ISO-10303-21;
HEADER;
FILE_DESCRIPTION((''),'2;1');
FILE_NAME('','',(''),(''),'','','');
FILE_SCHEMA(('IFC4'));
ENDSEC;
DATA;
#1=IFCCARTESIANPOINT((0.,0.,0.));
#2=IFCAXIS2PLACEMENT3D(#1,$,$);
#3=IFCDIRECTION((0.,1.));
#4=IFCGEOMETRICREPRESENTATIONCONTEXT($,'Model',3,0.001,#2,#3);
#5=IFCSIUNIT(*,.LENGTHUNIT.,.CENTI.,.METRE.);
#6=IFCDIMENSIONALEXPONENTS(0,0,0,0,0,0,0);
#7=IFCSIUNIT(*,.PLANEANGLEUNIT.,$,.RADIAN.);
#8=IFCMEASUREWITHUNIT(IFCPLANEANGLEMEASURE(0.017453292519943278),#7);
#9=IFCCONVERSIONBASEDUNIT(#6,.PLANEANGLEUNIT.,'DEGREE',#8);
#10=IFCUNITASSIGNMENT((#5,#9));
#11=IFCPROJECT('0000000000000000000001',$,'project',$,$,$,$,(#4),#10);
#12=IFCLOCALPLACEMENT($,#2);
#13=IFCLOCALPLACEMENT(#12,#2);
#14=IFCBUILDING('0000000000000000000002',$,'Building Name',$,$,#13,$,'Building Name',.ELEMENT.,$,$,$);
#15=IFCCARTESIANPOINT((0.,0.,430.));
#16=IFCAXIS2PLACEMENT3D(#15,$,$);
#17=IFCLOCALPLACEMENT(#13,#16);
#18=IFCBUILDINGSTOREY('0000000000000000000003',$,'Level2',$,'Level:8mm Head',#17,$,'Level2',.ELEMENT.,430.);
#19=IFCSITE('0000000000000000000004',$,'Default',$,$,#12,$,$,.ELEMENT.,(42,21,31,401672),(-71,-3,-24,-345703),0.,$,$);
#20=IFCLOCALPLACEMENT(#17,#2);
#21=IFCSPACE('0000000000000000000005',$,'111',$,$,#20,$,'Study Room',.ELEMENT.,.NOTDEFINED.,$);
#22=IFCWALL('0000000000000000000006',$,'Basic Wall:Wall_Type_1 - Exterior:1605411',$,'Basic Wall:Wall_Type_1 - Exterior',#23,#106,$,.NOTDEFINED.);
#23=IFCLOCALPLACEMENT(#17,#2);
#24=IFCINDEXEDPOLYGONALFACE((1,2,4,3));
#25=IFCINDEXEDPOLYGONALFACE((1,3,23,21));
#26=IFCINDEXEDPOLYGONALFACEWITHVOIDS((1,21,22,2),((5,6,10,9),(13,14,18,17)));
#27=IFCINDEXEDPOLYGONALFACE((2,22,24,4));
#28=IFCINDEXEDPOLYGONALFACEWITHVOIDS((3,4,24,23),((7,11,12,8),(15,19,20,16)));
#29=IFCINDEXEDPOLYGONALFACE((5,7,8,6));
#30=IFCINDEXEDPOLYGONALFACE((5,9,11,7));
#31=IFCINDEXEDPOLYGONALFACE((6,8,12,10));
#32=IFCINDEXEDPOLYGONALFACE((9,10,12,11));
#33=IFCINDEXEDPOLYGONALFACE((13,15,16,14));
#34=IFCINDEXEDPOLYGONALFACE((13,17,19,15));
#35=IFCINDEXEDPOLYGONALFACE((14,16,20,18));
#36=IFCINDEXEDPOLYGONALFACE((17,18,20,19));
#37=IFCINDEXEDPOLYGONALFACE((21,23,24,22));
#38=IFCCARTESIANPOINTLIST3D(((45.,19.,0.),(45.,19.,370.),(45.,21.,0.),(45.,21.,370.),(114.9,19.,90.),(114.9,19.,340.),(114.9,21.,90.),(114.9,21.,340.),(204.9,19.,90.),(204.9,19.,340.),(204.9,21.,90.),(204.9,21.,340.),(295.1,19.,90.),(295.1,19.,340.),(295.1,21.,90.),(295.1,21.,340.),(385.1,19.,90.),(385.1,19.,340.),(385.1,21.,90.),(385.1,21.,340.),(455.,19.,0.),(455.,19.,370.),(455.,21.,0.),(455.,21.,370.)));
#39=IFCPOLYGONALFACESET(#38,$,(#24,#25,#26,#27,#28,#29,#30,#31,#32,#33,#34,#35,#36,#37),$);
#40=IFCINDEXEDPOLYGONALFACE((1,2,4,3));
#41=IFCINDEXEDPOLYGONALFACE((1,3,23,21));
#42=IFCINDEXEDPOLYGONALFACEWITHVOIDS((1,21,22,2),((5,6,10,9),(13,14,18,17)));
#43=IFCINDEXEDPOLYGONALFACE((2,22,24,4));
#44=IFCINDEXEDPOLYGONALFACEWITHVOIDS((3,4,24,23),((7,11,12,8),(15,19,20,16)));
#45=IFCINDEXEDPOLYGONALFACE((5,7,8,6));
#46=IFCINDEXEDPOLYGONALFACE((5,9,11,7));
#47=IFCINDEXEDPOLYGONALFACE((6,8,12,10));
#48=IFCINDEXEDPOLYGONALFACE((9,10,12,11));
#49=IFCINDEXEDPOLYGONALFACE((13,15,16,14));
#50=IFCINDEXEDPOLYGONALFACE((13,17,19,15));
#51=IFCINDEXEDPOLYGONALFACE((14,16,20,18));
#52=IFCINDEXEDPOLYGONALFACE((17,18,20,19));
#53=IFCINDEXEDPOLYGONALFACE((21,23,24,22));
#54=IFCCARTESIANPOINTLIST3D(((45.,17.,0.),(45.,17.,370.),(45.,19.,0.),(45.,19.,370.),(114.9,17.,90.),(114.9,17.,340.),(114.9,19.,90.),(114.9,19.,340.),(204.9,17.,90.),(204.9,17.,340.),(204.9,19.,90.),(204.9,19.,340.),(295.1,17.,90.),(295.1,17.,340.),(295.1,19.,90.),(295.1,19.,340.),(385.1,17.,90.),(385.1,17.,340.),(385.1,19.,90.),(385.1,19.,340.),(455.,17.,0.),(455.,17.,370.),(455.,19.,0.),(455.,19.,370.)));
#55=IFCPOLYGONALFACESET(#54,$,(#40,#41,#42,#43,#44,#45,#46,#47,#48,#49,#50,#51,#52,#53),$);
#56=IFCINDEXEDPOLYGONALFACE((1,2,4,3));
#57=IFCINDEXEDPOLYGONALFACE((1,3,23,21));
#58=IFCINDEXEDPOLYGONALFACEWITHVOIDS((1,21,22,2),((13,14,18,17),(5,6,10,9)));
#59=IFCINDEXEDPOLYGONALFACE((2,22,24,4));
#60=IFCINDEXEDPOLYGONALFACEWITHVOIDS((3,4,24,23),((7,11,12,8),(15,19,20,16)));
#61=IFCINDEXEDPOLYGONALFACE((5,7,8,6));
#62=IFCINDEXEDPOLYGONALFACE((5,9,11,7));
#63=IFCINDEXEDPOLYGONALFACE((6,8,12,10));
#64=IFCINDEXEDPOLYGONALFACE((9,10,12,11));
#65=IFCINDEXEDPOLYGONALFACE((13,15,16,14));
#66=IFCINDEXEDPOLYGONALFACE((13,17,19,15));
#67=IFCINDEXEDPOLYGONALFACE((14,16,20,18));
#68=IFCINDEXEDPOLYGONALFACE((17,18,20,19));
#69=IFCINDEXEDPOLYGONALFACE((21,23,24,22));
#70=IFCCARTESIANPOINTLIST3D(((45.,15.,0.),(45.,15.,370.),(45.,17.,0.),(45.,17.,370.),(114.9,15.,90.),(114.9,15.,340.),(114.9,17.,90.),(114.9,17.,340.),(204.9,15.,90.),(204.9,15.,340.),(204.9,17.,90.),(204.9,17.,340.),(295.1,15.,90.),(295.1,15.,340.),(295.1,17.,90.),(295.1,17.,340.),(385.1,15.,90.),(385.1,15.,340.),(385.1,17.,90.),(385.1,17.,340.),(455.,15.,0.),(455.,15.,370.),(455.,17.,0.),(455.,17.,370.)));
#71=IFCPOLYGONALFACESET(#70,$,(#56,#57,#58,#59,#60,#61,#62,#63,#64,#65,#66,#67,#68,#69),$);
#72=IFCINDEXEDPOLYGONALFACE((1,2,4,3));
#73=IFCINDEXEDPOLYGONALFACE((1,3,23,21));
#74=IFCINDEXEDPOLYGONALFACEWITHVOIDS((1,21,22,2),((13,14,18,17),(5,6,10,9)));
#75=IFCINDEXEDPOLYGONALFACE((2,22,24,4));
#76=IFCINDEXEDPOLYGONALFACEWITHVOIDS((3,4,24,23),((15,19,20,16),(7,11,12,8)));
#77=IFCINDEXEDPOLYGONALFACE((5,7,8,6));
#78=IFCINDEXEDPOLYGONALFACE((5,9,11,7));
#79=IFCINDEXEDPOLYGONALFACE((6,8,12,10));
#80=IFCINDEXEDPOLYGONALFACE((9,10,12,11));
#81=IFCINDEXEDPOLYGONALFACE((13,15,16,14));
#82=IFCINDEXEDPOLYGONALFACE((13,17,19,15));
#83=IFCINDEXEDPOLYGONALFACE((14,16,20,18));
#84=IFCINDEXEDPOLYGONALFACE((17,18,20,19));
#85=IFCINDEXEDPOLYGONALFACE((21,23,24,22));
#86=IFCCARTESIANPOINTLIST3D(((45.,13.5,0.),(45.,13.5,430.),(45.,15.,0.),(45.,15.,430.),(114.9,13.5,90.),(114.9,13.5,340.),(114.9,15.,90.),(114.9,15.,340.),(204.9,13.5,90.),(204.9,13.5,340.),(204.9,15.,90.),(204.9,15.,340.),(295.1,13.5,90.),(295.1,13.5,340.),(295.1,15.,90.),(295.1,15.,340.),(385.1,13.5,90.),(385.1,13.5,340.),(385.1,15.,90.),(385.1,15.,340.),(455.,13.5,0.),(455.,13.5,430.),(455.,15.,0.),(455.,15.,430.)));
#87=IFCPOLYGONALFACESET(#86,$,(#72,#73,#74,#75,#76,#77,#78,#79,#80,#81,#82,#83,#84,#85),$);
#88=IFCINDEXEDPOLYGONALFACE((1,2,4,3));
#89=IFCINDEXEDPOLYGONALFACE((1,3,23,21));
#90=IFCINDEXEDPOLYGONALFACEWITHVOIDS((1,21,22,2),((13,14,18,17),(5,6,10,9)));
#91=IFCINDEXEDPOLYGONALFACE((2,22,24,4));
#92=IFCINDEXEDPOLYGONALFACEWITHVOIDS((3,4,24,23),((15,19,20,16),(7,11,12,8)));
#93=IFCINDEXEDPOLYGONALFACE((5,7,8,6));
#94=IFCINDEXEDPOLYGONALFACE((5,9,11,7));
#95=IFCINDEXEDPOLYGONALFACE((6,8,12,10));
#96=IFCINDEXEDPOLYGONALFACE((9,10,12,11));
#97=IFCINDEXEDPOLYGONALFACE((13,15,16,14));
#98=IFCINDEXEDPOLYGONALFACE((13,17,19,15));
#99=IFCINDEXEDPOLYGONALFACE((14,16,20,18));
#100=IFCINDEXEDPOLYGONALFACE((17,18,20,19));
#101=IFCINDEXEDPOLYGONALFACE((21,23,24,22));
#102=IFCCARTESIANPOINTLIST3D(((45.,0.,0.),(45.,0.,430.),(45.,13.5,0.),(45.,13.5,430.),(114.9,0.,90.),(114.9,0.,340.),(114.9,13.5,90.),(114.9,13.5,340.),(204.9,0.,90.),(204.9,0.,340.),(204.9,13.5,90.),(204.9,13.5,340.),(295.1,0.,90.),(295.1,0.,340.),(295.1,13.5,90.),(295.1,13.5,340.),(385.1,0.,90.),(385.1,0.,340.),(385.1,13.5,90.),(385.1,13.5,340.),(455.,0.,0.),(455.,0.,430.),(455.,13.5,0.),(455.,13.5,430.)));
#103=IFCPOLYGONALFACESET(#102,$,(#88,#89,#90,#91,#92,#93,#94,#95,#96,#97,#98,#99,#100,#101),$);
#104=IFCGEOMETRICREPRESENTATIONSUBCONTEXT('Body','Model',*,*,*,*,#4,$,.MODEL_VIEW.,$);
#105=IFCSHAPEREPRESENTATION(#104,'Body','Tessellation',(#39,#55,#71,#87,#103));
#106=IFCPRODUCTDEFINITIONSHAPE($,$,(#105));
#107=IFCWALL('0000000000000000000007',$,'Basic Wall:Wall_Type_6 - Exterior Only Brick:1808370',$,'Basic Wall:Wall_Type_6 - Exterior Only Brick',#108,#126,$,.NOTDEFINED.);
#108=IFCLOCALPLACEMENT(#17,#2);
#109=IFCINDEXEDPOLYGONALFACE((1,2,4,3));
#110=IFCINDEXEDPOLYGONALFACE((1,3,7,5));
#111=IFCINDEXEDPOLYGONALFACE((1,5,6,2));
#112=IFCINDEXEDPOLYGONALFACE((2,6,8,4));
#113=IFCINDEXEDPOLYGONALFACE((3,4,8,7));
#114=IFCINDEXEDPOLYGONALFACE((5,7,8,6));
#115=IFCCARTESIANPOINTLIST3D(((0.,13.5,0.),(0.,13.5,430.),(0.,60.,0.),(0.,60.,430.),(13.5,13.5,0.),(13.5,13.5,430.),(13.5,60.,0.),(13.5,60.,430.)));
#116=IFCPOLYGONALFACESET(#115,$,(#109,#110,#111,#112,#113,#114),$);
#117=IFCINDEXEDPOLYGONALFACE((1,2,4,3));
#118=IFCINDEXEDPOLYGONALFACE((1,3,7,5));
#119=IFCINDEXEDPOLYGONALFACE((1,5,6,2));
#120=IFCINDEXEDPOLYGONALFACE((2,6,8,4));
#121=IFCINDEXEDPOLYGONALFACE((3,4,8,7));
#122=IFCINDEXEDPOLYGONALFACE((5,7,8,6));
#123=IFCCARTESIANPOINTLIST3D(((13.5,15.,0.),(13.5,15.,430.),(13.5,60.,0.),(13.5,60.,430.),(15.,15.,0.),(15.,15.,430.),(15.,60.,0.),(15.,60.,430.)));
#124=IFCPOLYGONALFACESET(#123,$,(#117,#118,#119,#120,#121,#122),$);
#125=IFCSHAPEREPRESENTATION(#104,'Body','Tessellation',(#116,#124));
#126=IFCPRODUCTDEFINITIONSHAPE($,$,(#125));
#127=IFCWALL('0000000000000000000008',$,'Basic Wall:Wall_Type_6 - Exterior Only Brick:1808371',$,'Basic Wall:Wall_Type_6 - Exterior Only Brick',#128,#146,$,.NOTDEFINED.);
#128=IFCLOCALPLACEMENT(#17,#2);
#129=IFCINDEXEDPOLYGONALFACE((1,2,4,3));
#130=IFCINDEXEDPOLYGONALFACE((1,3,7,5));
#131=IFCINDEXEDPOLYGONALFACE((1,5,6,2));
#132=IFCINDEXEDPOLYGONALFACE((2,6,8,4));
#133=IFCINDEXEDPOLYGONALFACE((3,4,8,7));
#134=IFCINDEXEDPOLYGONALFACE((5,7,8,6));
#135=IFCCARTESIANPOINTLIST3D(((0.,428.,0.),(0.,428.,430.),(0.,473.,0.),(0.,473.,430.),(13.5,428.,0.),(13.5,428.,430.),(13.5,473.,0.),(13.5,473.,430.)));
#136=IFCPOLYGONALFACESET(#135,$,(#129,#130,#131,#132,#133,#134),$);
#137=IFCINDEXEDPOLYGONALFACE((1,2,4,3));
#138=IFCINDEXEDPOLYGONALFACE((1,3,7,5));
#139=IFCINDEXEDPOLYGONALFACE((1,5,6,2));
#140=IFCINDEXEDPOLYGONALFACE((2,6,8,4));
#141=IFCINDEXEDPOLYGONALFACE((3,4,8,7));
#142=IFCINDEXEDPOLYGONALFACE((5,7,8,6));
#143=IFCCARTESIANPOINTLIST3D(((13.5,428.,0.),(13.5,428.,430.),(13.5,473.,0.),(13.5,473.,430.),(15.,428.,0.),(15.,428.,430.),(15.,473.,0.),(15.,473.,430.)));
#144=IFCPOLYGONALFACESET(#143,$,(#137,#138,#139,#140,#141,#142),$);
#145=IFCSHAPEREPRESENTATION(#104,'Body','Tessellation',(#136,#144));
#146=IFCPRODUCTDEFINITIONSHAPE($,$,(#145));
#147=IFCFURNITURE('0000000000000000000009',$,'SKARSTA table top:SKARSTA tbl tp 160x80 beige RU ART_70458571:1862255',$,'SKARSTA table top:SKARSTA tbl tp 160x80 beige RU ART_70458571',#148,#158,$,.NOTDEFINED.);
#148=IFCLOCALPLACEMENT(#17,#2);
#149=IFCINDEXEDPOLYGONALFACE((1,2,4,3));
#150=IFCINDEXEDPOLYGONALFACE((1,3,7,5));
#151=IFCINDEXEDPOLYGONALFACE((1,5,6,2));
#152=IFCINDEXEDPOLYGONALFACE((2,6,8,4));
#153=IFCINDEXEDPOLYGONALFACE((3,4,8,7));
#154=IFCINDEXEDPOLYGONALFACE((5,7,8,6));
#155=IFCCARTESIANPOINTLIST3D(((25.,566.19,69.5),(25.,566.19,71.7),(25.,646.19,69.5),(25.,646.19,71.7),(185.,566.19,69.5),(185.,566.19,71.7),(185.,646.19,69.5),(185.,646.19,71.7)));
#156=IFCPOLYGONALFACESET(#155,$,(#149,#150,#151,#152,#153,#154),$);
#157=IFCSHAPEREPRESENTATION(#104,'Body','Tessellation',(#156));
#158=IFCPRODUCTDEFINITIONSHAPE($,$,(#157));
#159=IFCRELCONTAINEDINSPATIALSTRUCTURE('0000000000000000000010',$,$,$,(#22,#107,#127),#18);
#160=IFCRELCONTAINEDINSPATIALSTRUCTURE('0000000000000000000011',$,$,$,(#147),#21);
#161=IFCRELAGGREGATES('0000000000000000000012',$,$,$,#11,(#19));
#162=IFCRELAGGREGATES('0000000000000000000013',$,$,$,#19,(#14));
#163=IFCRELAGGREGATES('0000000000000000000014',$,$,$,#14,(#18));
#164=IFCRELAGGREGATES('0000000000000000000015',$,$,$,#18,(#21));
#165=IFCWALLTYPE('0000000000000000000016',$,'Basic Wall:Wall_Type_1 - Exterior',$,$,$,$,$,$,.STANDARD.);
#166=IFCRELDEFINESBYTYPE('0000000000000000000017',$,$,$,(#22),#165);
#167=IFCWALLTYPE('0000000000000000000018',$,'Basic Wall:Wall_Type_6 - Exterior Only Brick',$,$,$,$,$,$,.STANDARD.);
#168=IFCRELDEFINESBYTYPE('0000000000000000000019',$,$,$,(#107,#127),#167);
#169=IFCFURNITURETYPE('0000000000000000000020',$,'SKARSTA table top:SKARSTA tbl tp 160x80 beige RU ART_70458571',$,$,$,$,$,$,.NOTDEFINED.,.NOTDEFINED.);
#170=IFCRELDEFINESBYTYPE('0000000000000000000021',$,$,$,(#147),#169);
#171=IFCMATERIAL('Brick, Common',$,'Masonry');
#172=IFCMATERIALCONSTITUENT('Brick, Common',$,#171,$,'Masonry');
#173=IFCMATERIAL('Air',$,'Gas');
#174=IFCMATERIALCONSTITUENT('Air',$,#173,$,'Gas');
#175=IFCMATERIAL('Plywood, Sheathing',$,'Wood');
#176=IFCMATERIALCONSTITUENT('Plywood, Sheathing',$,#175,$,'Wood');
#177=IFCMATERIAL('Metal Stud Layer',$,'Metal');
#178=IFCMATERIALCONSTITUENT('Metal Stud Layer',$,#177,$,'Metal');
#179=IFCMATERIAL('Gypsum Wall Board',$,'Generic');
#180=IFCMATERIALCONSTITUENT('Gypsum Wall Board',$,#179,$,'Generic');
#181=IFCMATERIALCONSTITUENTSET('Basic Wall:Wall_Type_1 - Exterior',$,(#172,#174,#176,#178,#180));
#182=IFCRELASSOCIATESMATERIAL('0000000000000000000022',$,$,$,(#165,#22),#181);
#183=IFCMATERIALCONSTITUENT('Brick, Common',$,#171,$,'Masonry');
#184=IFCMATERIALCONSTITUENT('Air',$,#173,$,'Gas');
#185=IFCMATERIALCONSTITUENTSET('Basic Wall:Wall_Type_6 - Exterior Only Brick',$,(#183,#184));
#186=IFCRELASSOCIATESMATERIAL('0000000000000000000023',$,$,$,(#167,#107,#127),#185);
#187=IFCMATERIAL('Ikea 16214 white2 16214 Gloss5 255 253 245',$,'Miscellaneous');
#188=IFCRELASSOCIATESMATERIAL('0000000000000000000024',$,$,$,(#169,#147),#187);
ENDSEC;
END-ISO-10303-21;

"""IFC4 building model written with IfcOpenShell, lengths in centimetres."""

from ifc_helpers import new_model, entity, si_unit, converted_unit, direction, frame, origin, place, context, subcontext, project, spatial, indexed_curve, outline, extrude, source, transform, mapped, material, constituent, constituent_set, type_object, type_shapes, element, save


model = new_model("IFC4")

# Units and contexts
model_context = context("Model", 3, precision=0.001, world=origin(), true_north=direction((0.0, 1.0)))
body_context = subcontext(model_context, "Body", "Model", "MODEL_VIEW")
ifc_project = project(units=[si_unit("LENGTHUNIT", "METRE", prefix="CENTI"), converted_unit("PLANEANGLEUNIT", "DEGREE", entity("IfcPlaneAngleMeasure", 0.017453292519943278), si_unit("PLANEANGLEUNIT", "RADIAN"), dimensions=[0, 0, 0, 0, 0, 0, 0])], contexts=[model_context])

# Site, building, storey
site_placement = place(None, origin())
site = spatial("IfcSite", under=ifc_project, at=site_placement, Name="Default", CompositionType="ELEMENT", RefLatitude=(42, 21, 31, 401672), RefLongitude=(-71, -3, -24, -345703), RefElevation=0.0)
building_placement = place(site_placement, origin())
building = spatial("IfcBuilding", under=site, at=building_placement, Name="Building Name", LongName="Building Name", CompositionType="ELEMENT")
storey_placement = place(building_placement, frame((0.0, 0.0, 430.0)))
storey = spatial("IfcBuildingStorey", under=building, at=storey_placement, Name="Level2", ObjectType="Level:8mm Head", LongName="Level2", CompositionType="ELEMENT", Elevation=430.0)

# Shared definitions
ifc_material_1 = material(Name="Brick, Common", Category="Masonry")
ifc_constituent_1 = constituent(ifc_material_1, Name="Brick, Common", Category="Masonry")
ifc_material_2 = material(Name="Air", Category="Gas")
ifc_constituent_2 = constituent(ifc_material_2, Name="Air", Category="Gas")
ifc_material_3 = material(Name="Plywood, Sheathing", Category="Wood")
ifc_constituent_3 = constituent(ifc_material_3, Name="Plywood, Sheathing", Category="Wood")
ifc_material_4 = material(Name="Metal Stud Layer", Category="Metal")
ifc_constituent_4 = constituent(ifc_material_4, Name="Metal Stud Layer", Category="Metal")
ifc_material_5 = material(Name="Gypsum Wall Board", Category="Generic")
ifc_constituent_5 = constituent(ifc_material_5, Name="Gypsum Wall Board", Category="Generic")
ifc_constituent_set_1 = constituent_set(constituents=[ifc_constituent_1, ifc_constituent_2, ifc_constituent_3, ifc_constituent_4, ifc_constituent_5], Name="Basic Wall:Wall_Type_1 - Exterior")
wall_type_1 = type_object("IfcWallType", Name="Basic Wall:Wall_Type_1 - Exterior", PredefinedType="STANDARD", material=ifc_constituent_set_1)

# Wall, openings
wall_1_placement = place(storey_placement, frame((455.0, 10.5, 0.0), z_axis=(0.0, 0.0, 1.0), x_axis=(-1.0, 0.0, 0.0)))
wall_1 = element("IfcWall", 1, at=wall_1_placement, inside=storey, type_object=wall_type_1, material=ifc_constituent_set_1, Name="Basic Wall:Wall_Type_1 - Exterior:1605411", ObjectType="Basic Wall:Wall_Type_1 - Exterior", PredefinedType="NOTDEFINED", context=body_context, shape_type="SweptSolid", body=[
    extrude(outline(indexed_curve([(-185.0, -205.0), (185.0, -205.0), (185.0, 205.0), (-185.0, 205.0), (-185.0, -205.0)], self_intersect=False), holes=[indexed_curve([(-95.0, 45.1), (-95.0, 135.1), (155.0, 135.1), (155.0, 45.1), (-95.0, 45.1)], self_intersect=False), indexed_curve([(-95.0, -135.1), (-95.0, -45.1), (155.0, -45.1), (155.0, -135.1), (-95.0, -135.1)], self_intersect=False)]), frame((205.0, -8.5, 185.0), z_axis=(0.0, -1.0, 0.0), x_axis=(0.0, 0.0, 1.0)), (0.0, 0.0, 1.0), 2.0),
    extrude(outline(indexed_curve([(-185.0, -205.0), (185.0, -205.0), (185.0, 205.0), (-185.0, 205.0), (-185.0, -205.0)], self_intersect=False), holes=[indexed_curve([(-95.0, 45.1), (-95.0, 135.1), (155.0, 135.1), (155.0, 45.1), (-95.0, 45.1)], self_intersect=False), indexed_curve([(-95.0, -135.1), (-95.0, -45.1), (155.0, -45.1), (155.0, -135.1), (-95.0, -135.1)], self_intersect=False)]), frame((205.0, -6.5, 185.0), z_axis=(0.0, -1.0, 0.0), x_axis=(0.0, 0.0, 1.0)), (0.0, 0.0, 1.0), 2.0),
    extrude(outline(indexed_curve([(-185.0, -205.0), (185.0, -205.0), (185.0, 205.0), (-185.0, 205.0), (-185.0, -205.0)], self_intersect=False), holes=[indexed_curve([(-95.0, 45.1), (-95.0, 135.1), (155.0, 135.1), (155.0, 45.1), (-95.0, 45.1)], self_intersect=False), indexed_curve([(-95.0, -135.1), (-95.0, -45.1), (155.0, -45.1), (155.0, -135.1), (-95.0, -135.1)], self_intersect=False)]), frame((205.0, -4.5, 185.0), z_axis=(0.0, -1.0, 0.0), x_axis=(0.0, 0.0, 1.0)), (0.0, 0.0, 1.0), 2.0),
    extrude(outline(indexed_curve([(-215.0, -205.0), (215.0, -205.0), (215.0, 205.0), (-215.0, 205.0), (-215.0, -205.0)], self_intersect=False), holes=[indexed_curve([(-125.0, 45.1), (-125.0, 135.1), (125.0, 135.1), (125.0, 45.1), (-125.0, 45.1)], self_intersect=False), indexed_curve([(-125.0, -135.1), (-125.0, -45.1), (125.0, -45.1), (125.0, -135.1), (-125.0, -135.1)], self_intersect=False)]), frame((205.0, -3.0, 215.0), z_axis=(0.0, -1.0, 0.0), x_axis=(0.0, 0.0, 1.0)), (0.0, 0.0, 1.0), 1.5),
    extrude(outline(indexed_curve([(-215.0, -205.0), (215.0, -205.0), (215.0, 205.0), (-215.0, 205.0), (-215.0, -205.0)], self_intersect=False), holes=[indexed_curve([(-125.0, -135.1), (-125.0, -45.1), (125.0, -45.1), (125.0, -135.1), (-125.0, -135.1)], self_intersect=False), indexed_curve([(-125.0, 45.1), (-125.0, 135.1), (125.0, 135.1), (125.0, 45.1), (-125.0, 45.1)], self_intersect=False)]), frame((205.0, 10.5, 215.0), z_axis=(0.0, -1.0, 0.0), x_axis=(0.0, 0.0, 1.0)), (0.0, 0.0, 1.0), 13.5),
])
opening_1_placement = place(wall_1_placement, frame((159.9, 10.5, 90.0)))
element("IfcOpeningElement", 2, at=opening_1_placement, cuts=wall_1, PredefinedType="OPENING", context=body_context, shape_type="SweptSolid", body=[
    extrude(outline(indexed_curve([(250.0, 0.0), (250.0, 90.0), (0.0, 90.0), (0.0, 0.0), (250.0, 0.0)], self_intersect=False)), frame((0.0, 0.0, 0.0), z_axis=(0.0, -1.0, 0.0), x_axis=(0.0, 0.0, 1.0)), (0.0, 0.0, 1.0), 21.0),
])
opening_2_placement = place(wall_1_placement, frame((340.1, 10.5, 90.0)))
element("IfcOpeningElement", 3, at=opening_2_placement, cuts=wall_1, PredefinedType="OPENING", context=body_context, shape_type="SweptSolid", body=[
    extrude(outline(indexed_curve([(250.0, 0.0), (250.0, 90.0), (0.0, 90.0), (0.0, 0.0), (250.0, 0.0)], self_intersect=False)), frame((0.0, 0.0, 0.0), z_axis=(0.0, -1.0, 0.0), x_axis=(0.0, 0.0, 1.0)), (0.0, 0.0, 1.0), 21.0),
])

# Walls
ifc_constituent_6 = constituent(ifc_material_1, Name="Brick, Common", Category="Masonry")
ifc_constituent_7 = constituent(ifc_material_2, Name="Air", Category="Gas")
ifc_constituent_set_2 = constituent_set(constituents=[ifc_constituent_6, ifc_constituent_7], Name="Basic Wall:Wall_Type_6 - Exterior Only Brick")
wall_type_2 = type_object("IfcWallType", Name="Basic Wall:Wall_Type_6 - Exterior Only Brick", PredefinedType="STANDARD", material=ifc_constituent_set_2)
wall_2_placement = place(storey_placement, frame((7.5, 15.0, 0.0), z_axis=(0.0, 0.0, 1.0), x_axis=(0.0, 1.0, 0.0)))
element("IfcWall", 4, at=wall_2_placement, inside=storey, type_object=wall_type_2, material=ifc_constituent_set_2, Name="Basic Wall:Wall_Type_6 - Exterior Only Brick:1808370", ObjectType="Basic Wall:Wall_Type_6 - Exterior Only Brick", PredefinedType="NOTDEFINED", context=body_context, shape_type="SweptSolid", body=[
    extrude(outline(indexed_curve([(-6.75, -23.25), (6.75, -23.25), (6.75, 23.25), (-6.75, 23.25), (-6.75, -23.25)], self_intersect=False)), frame((21.75, 0.75, 0.0), z_axis=(0.0, 0.0, 1.0), x_axis=(0.0, -1.0, 0.0)), (0.0, 0.0, 1.0), 430.0),
    extrude(outline(indexed_curve([(-0.75, -22.5), (0.75, -22.5), (0.75, 22.5), (-0.75, 22.5), (-0.75, -22.5)], self_intersect=False)), frame((22.5, -6.75, 0.0), z_axis=(0.0, 0.0, 1.0), x_axis=(0.0, 1.0, 0.0)), (0.0, 0.0, 1.0), 430.0),
])
wall_3_placement = place(storey_placement, frame((7.5, 428.0, 0.0), z_axis=(0.0, 0.0, 1.0), x_axis=(0.0, 1.0, 0.0)))
element("IfcWall", 5, at=wall_3_placement, inside=storey, type_object=wall_type_2, material=ifc_constituent_set_2, Name="Basic Wall:Wall_Type_6 - Exterior Only Brick:1808371", ObjectType="Basic Wall:Wall_Type_6 - Exterior Only Brick", PredefinedType="NOTDEFINED", context=body_context, shape_type="SweptSolid", body=[
    extrude(outline(indexed_curve([(-6.75, -22.5), (6.75, -22.5), (6.75, 22.5), (-6.75, 22.5), (-6.75, -22.5)], self_intersect=False)), frame((22.5, 0.75, 0.0), z_axis=(0.0, 0.0, 1.0), x_axis=(0.0, -1.0, 0.0)), (0.0, 0.0, 1.0), 430.0),
    extrude(outline(indexed_curve([(-0.75, -22.5), (0.75, -22.5), (0.75, 22.5), (-0.75, 22.5), (-0.75, -22.5)], self_intersect=False)), frame((22.5, -6.75, 0.0), z_axis=(0.0, 0.0, 1.0), x_axis=(0.0, 1.0, 0.0)), (0.0, 0.0, 1.0), 430.0),
])

# Shared definitions
space_placement = place(storey_placement, origin())
space = spatial("IfcSpace", under=storey, at=space_placement, Name="111", LongName="Study Room", CompositionType="ELEMENT", PredefinedType="NOTDEFINED")

# Furniture
ifc_material_6 = material(Name="Ikea 16214 white2 16214 Gloss5 255 253 245", Category="Miscellaneous")
furniture_type = type_object("IfcFurnitureType", Name="SKARSTA table top:SKARSTA tbl tp 160x80 beige RU ART_70458571", AssemblyPlace="NOTDEFINED", PredefinedType="NOTDEFINED", material=ifc_material_6)
shared_shape_1 = source(origin(), body_context, "Body", "SweptSolid", [
    extrude(outline(indexed_curve([(-40.0, -80.0), (40.0, -80.0), (40.0, 80.0), (-40.0, 80.0), (-40.0, -80.0)], self_intersect=False)), frame((0.0, 0.0, 0.0), z_axis=(0.0, 0.0, 1.0), x_axis=(0.0, 1.0, 0.0)), (0.0, 0.0, 1.0), 2.2),
])
type_shapes(furniture_type, [shared_shape_1])
for number, where, z_axis, x_axis, name in (
    (6, (105.0, 606.19, 69.5), (0.0, 0.0, 1.0), (-1.0, 0.0, 0.0), "SKARSTA table top:SKARSTA tbl tp 160x80 beige RU ART_70458571:1862255"),
):
    element("IfcFurniture", number, at=place(space_placement, frame(where, z_axis=z_axis, x_axis=x_axis)), inside=space, type_object=furniture_type, material=ifc_material_6, Name=name, ObjectType="SKARSTA table top:SKARSTA tbl tp 160x80 beige RU ART_70458571", PredefinedType="NOTDEFINED", context=body_context, shape_type="MappedRepresentation", body=[
        mapped(shared_shape_1, transform((0.0, 0.0, 0.0), scale=1.0)),
    ])

save(model, "model.ifc")
